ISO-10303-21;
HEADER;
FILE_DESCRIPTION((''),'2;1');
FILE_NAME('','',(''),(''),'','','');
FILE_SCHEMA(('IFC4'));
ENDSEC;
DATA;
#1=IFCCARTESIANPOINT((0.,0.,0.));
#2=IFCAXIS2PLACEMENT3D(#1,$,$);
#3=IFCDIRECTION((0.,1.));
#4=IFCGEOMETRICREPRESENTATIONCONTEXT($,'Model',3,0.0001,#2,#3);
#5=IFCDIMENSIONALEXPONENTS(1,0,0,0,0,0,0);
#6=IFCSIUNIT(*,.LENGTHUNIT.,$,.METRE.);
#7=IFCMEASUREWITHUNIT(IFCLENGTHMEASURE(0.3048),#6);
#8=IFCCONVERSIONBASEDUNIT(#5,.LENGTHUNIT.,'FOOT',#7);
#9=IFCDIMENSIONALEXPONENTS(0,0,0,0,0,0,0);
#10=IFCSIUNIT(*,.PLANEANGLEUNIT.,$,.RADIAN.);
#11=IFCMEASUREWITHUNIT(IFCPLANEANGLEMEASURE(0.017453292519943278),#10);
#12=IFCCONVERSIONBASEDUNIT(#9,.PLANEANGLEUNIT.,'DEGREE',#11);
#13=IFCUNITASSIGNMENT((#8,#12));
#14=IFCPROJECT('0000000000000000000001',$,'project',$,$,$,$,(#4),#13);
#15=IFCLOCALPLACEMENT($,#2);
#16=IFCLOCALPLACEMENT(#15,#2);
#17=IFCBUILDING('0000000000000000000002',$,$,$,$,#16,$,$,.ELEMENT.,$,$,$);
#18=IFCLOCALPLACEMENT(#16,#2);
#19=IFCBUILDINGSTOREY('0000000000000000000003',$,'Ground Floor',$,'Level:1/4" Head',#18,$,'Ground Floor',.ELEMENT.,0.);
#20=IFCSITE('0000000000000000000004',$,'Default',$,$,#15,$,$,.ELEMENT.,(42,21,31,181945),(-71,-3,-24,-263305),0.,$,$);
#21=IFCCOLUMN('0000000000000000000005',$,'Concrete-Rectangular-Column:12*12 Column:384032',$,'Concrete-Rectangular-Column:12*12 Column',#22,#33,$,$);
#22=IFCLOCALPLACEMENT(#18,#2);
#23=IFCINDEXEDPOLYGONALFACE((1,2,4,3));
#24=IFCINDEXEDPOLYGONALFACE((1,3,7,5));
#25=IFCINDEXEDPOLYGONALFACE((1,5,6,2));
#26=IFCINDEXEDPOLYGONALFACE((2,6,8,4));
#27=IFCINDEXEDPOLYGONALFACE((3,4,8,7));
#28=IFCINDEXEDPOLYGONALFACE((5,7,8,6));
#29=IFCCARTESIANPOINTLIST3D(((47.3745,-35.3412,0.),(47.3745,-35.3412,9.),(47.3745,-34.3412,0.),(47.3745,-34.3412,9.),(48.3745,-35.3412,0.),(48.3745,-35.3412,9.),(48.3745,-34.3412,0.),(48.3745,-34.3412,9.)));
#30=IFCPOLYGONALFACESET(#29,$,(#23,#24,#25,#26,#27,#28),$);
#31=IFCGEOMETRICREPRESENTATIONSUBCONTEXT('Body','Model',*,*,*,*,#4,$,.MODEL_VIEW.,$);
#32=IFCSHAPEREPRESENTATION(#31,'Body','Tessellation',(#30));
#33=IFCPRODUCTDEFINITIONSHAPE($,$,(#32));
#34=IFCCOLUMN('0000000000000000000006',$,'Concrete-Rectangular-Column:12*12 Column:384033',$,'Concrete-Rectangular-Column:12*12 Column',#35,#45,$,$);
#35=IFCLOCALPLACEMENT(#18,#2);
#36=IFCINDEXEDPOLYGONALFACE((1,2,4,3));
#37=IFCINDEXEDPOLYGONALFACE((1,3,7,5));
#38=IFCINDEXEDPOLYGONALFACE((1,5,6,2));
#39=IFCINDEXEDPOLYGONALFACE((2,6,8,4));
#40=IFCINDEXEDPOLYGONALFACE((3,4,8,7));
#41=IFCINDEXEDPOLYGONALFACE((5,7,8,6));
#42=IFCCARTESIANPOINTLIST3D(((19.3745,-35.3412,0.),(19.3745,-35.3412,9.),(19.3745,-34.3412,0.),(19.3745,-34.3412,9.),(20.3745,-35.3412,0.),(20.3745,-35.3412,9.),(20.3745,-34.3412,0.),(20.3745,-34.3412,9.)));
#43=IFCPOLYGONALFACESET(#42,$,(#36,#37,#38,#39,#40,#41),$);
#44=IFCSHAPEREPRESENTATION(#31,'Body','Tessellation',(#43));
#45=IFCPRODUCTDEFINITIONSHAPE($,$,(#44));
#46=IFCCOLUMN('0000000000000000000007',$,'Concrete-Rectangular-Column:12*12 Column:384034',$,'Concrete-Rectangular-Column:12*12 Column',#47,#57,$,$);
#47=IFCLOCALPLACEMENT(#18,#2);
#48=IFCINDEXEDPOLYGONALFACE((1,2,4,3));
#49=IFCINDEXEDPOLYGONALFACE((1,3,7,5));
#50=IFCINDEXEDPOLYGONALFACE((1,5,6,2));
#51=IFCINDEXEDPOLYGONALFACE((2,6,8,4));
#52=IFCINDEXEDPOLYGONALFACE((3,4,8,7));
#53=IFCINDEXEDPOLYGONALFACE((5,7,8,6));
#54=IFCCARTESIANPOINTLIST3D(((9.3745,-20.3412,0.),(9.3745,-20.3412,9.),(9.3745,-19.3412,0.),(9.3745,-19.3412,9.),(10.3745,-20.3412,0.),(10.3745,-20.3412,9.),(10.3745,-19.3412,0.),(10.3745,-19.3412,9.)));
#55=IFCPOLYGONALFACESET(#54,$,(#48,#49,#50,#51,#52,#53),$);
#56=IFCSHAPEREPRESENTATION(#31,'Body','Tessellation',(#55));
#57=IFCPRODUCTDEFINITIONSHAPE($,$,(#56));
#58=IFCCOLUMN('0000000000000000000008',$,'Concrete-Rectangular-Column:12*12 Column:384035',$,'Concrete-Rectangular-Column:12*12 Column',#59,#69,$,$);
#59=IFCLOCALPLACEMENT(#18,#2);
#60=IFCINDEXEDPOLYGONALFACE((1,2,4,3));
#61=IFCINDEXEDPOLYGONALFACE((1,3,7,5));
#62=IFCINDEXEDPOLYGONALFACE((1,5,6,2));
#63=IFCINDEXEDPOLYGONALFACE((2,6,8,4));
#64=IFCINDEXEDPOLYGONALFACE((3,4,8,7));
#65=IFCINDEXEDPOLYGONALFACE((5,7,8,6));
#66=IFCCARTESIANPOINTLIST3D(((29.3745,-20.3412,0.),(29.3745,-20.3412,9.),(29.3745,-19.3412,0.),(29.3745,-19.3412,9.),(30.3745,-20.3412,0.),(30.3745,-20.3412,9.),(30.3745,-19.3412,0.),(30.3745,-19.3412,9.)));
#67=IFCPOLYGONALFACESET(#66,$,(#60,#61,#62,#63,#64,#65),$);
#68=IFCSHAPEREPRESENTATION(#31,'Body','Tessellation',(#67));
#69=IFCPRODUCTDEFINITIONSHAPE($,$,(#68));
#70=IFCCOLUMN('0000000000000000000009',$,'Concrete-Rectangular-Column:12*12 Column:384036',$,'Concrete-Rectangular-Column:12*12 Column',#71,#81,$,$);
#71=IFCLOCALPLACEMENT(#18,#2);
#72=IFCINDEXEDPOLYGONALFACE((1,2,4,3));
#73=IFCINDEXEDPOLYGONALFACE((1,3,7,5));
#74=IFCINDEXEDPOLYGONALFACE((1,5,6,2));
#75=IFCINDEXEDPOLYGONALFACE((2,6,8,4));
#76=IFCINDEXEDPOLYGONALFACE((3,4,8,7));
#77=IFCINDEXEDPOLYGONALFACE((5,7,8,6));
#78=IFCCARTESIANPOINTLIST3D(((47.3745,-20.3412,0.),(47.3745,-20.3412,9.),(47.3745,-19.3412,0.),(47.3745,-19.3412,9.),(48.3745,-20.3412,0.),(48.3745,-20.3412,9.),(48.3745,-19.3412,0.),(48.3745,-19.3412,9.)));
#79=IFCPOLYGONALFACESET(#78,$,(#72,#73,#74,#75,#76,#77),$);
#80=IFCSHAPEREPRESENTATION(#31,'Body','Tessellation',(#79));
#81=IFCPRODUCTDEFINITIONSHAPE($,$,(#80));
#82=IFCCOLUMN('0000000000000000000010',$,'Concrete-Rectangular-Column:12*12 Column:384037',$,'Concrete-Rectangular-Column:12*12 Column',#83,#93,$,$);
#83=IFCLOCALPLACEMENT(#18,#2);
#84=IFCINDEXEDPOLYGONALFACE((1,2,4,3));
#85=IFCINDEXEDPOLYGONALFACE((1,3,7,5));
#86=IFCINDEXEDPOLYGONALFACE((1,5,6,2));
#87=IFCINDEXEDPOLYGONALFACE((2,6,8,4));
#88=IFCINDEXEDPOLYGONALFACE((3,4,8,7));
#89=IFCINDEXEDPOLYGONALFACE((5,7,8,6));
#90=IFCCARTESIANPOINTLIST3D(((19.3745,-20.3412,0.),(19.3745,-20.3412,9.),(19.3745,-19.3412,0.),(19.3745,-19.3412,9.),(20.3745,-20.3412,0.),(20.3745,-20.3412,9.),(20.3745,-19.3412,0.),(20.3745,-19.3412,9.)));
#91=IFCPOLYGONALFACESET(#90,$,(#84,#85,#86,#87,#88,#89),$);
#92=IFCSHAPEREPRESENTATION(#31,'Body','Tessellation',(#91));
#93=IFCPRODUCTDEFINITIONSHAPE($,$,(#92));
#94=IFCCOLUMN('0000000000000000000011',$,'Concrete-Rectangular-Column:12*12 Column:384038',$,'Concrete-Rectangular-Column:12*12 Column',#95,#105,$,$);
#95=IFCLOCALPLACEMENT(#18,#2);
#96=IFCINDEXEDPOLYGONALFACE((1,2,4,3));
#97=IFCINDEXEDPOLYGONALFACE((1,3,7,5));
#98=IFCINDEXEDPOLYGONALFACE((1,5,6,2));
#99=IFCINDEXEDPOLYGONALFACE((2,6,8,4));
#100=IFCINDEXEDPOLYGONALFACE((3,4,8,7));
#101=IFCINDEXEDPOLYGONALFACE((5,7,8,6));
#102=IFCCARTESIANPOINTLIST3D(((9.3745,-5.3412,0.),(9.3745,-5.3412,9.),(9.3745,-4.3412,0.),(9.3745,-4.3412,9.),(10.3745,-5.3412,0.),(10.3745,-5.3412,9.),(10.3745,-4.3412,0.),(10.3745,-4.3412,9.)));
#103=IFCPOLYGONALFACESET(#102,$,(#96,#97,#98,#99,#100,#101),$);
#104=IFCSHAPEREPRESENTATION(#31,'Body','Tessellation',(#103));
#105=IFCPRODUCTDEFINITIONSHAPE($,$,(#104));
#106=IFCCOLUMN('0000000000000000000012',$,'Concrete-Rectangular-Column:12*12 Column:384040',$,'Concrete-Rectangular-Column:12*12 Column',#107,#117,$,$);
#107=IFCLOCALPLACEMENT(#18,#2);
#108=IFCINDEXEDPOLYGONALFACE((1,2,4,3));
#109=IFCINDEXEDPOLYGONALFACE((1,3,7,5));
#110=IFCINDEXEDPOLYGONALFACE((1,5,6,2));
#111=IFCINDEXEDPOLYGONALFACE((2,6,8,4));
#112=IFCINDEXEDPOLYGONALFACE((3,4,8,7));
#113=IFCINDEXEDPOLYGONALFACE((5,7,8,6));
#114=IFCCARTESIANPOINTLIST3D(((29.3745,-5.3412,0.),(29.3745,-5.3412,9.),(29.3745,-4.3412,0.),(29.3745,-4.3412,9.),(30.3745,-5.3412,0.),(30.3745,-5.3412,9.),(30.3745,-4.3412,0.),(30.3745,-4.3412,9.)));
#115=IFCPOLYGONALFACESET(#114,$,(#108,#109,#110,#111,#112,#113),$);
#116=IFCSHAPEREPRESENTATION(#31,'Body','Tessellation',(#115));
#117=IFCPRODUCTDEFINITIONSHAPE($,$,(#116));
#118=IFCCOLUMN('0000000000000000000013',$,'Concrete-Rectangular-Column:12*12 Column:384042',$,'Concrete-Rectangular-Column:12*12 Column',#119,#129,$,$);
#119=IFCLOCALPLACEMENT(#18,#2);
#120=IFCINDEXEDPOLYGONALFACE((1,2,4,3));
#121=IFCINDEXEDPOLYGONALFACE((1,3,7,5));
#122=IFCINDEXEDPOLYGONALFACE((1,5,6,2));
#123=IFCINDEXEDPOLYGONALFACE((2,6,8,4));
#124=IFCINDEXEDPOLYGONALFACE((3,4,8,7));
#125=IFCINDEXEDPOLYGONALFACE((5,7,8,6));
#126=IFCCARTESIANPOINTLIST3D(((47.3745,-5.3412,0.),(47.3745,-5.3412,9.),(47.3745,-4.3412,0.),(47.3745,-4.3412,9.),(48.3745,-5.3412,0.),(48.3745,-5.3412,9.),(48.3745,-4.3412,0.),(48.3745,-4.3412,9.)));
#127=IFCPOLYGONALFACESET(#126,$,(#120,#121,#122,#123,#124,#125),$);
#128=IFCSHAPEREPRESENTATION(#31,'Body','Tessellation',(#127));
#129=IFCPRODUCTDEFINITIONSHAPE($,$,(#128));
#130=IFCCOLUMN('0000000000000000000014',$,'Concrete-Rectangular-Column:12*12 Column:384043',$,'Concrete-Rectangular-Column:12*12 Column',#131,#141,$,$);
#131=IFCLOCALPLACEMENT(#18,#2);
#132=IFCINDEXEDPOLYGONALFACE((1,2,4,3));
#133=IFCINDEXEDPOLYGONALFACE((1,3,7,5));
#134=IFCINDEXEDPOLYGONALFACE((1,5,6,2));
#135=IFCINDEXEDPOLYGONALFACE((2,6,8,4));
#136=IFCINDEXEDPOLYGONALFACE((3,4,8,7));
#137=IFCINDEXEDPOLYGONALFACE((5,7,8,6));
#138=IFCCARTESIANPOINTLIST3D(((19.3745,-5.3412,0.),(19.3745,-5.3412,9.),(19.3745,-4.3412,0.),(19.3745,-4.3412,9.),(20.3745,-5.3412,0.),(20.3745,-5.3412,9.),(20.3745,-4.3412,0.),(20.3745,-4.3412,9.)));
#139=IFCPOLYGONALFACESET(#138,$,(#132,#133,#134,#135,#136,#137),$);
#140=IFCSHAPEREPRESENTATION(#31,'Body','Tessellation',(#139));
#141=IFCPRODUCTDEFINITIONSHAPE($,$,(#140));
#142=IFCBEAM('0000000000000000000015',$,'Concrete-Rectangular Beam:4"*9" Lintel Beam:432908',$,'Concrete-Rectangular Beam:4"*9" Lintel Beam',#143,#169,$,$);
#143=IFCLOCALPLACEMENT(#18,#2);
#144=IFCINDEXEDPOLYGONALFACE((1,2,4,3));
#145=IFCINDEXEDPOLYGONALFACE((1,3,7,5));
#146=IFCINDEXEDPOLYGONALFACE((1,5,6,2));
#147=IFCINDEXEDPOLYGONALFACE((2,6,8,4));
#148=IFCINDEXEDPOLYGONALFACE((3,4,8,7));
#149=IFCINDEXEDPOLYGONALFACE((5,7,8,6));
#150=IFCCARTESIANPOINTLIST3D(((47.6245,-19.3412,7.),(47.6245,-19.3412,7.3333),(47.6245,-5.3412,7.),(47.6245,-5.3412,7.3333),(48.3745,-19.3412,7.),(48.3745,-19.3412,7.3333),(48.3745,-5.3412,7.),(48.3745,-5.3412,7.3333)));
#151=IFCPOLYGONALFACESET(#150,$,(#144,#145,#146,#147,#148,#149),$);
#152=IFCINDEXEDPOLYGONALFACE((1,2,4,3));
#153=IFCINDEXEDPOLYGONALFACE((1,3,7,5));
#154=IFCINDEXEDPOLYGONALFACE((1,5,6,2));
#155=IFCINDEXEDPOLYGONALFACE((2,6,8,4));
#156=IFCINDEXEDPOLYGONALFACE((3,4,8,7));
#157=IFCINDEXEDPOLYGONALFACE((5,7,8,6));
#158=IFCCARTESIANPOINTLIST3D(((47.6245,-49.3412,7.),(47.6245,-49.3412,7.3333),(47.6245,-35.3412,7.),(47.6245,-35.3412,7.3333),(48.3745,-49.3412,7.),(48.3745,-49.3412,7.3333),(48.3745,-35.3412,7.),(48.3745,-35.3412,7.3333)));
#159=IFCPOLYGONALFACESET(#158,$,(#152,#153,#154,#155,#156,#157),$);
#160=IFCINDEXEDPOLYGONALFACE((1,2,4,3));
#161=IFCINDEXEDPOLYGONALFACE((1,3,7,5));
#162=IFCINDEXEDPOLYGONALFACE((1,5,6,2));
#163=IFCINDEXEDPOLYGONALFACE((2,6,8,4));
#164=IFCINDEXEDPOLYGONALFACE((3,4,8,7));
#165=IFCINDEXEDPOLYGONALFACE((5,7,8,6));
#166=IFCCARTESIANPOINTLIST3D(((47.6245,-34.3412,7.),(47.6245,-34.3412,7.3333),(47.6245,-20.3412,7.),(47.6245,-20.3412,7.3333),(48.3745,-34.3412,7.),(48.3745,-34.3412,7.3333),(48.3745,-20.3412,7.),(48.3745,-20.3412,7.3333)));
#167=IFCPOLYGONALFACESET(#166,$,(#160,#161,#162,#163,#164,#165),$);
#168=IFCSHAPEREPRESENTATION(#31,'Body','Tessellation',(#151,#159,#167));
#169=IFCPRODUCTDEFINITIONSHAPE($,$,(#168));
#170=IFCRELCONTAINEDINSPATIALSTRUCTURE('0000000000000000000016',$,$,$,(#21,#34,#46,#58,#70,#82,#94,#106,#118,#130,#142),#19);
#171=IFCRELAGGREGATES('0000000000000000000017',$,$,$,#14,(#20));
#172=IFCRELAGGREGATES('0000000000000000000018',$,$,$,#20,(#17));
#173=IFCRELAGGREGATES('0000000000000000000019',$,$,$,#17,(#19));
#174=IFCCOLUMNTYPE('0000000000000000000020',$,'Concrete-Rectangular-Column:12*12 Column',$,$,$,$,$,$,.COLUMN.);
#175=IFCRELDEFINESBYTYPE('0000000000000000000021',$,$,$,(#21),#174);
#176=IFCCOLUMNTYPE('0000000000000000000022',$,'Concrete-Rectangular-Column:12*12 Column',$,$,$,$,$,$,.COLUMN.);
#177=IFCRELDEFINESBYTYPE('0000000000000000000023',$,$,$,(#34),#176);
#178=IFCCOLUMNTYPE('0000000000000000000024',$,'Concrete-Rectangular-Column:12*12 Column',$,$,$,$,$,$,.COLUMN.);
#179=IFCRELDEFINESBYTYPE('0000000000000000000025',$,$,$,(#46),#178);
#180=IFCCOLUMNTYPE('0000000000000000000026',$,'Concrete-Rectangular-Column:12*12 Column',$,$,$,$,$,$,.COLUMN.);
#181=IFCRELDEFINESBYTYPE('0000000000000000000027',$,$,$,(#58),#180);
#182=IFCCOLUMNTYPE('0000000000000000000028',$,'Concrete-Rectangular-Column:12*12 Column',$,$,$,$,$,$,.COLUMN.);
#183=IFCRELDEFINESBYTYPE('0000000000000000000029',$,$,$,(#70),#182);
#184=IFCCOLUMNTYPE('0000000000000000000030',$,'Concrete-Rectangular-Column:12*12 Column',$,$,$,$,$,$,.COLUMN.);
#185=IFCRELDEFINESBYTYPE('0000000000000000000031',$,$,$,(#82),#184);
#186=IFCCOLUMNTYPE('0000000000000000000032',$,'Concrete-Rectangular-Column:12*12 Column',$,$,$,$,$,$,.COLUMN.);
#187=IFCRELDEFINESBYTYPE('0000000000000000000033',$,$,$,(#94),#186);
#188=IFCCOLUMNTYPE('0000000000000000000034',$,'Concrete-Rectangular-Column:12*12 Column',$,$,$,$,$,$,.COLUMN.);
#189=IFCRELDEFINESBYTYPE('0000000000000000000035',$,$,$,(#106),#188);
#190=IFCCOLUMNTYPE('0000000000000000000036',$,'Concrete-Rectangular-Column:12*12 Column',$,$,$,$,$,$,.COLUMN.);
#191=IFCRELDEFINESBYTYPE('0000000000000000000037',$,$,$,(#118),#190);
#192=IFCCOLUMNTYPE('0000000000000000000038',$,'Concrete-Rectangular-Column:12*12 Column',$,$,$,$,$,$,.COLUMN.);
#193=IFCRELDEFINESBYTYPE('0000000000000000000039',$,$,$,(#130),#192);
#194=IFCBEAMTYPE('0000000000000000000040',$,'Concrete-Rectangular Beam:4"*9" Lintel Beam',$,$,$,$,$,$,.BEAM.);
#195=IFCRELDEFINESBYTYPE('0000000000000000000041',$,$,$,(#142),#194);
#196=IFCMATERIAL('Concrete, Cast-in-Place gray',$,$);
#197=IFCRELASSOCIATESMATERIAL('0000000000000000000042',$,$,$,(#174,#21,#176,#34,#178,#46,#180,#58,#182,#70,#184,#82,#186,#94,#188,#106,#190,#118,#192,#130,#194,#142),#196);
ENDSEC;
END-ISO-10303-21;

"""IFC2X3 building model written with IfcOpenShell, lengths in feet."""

from ifc_helpers import new_model, entity, si_unit, converted_unit, direction, frame, frame_2d, origin, origin_2d_with_axis, place, context, subcontext, project, spatial, rectangle, extrude, source, transform, mapped, material, type_object, type_shapes, element, save


model = new_model("IFC2X3")

# Units and contexts
model_context = context("Model", 3, precision=0.0001, world=origin(), true_north=direction((0.0, 1.0)))
body_context = subcontext(model_context, "Body", "Model", "MODEL_VIEW")
ifc_project = project(units=[converted_unit("LENGTHUNIT", "FOOT", entity("IfcLengthMeasure", 0.3048), si_unit("LENGTHUNIT", "METRE"), dimensions=[1, 0, 0, 0, 0, 0, 0]), converted_unit("PLANEANGLEUNIT", "DEGREE", entity("IfcPlaneAngleMeasure", 0.017453292519943278), si_unit("PLANEANGLEUNIT", "RADIAN"), dimensions=[0, 0, 0, 0, 0, 0, 0])], contexts=[model_context])

# Site, building, storey
site_placement = place(None, origin())
site = spatial("IfcSite", under=ifc_project, at=site_placement, Name="Default", CompositionType="ELEMENT", RefLatitude=(42, 21, 31, 181945), RefLongitude=(-71, -3, -24, -263305), RefElevation=0.0)
building_placement = place(site_placement, origin())
building = spatial("IfcBuilding", under=site, at=building_placement, CompositionType="ELEMENT")
storey_placement = place(building_placement, origin())
storey = spatial("IfcBuildingStorey", under=building, at=storey_placement, Name="Ground Floor", ObjectType="Level:1/4\" Head", LongName="Ground Floor", CompositionType="ELEMENT", Elevation=0.0)

# Columns
ifc_material_1 = material(Name="Concrete, Cast-in-Place gray")
column_type_1 = type_object("IfcColumnType", Name="Concrete-Rectangular-Column:12*12 Column", PredefinedType="COLUMN", material=ifc_material_1)
shared_shape_1 = source(origin(), body_context, "Body", "SweptSolid", [
    extrude(rectangle(XDim=1.0, YDim=1.0, at=origin_2d_with_axis()), frame((47.8745, -34.8412, 0.0), z_axis=(0.0, 0.0, 1.0), x_axis=(-1.0, 0.0, 0.0)), (0.0, 0.0, 1.0), 9.0),
])
type_shapes(column_type_1, [shared_shape_1])
column_1_placement = place(storey_placement, origin())
element("IfcColumn", 1, at=column_1_placement, inside=storey, type_object=column_type_1, material=ifc_material_1, Name="Concrete-Rectangular-Column:12*12 Column:384032", ObjectType="Concrete-Rectangular-Column:12*12 Column", context=body_context, shape_type="MappedRepresentation", body=[
    mapped(shared_shape_1, transform((0.0, 0.0, 0.0), scale=1.0)),
])
column_type_2 = type_object("IfcColumnType", Name="Concrete-Rectangular-Column:12*12 Column", PredefinedType="COLUMN", material=ifc_material_1)
shared_shape_2 = source(origin(), body_context, "Body", "SweptSolid", [
    extrude(rectangle(XDim=1.0, YDim=1.0, at=frame_2d((0.0, 0.0), x_axis=(1.0, 0.0))), frame((19.8745, -34.8412, 0.0), z_axis=(0.0, 0.0, 1.0), x_axis=(-1.0, 0.0, 0.0)), (0.0, 0.0, 1.0), 9.0),
])
type_shapes(column_type_2, [shared_shape_2])
column_2_placement = place(storey_placement, origin())
element("IfcColumn", 2, at=column_2_placement, inside=storey, type_object=column_type_2, material=ifc_material_1, Name="Concrete-Rectangular-Column:12*12 Column:384033", ObjectType="Concrete-Rectangular-Column:12*12 Column", context=body_context, shape_type="MappedRepresentation", body=[
    mapped(shared_shape_2, transform((0.0, 0.0, 0.0), scale=1.0)),
])
column_type_3 = type_object("IfcColumnType", Name="Concrete-Rectangular-Column:12*12 Column", PredefinedType="COLUMN", material=ifc_material_1)
shared_shape_3 = source(origin(), body_context, "Body", "SweptSolid", [
    extrude(rectangle(XDim=1.0, YDim=1.0, at=frame_2d((0.0, 0.0), x_axis=(1.0, 0.0))), frame((9.8745, -19.8412, 0.0), z_axis=(0.0, 0.0, 1.0), x_axis=(-1.0, 0.0, 0.0)), (0.0, 0.0, 1.0), 9.0),
])
type_shapes(column_type_3, [shared_shape_3])
column_3_placement = place(storey_placement, origin())
element("IfcColumn", 3, at=column_3_placement, inside=storey, type_object=column_type_3, material=ifc_material_1, Name="Concrete-Rectangular-Column:12*12 Column:384034", ObjectType="Concrete-Rectangular-Column:12*12 Column", context=body_context, shape_type="MappedRepresentation", body=[
    mapped(shared_shape_3, transform((0.0, 0.0, 0.0), scale=1.0)),
])
column_type_4 = type_object("IfcColumnType", Name="Concrete-Rectangular-Column:12*12 Column", PredefinedType="COLUMN", material=ifc_material_1)
shared_shape_4 = source(origin(), body_context, "Body", "SweptSolid", [
    extrude(rectangle(XDim=1.0, YDim=1.0, at=frame_2d((0.0, 0.0), x_axis=(1.0, 0.0))), frame((29.8745, -19.8412, 0.0), z_axis=(0.0, 0.0, 1.0), x_axis=(-1.0, 0.0, 0.0)), (0.0, 0.0, 1.0), 9.0),
])
type_shapes(column_type_4, [shared_shape_4])
column_4_placement = place(storey_placement, origin())
element("IfcColumn", 4, at=column_4_placement, inside=storey, type_object=column_type_4, material=ifc_material_1, Name="Concrete-Rectangular-Column:12*12 Column:384035", ObjectType="Concrete-Rectangular-Column:12*12 Column", context=body_context, shape_type="MappedRepresentation", body=[
    mapped(shared_shape_4, transform((0.0, 0.0, 0.0), scale=1.0)),
])
column_type_5 = type_object("IfcColumnType", Name="Concrete-Rectangular-Column:12*12 Column", PredefinedType="COLUMN", material=ifc_material_1)
shared_shape_5 = source(origin(), body_context, "Body", "SweptSolid", [
    extrude(rectangle(XDim=1.0, YDim=1.0, at=frame_2d((0.0, 0.0), x_axis=(1.0, 0.0))), frame((47.8745, -19.8412, 0.0), z_axis=(0.0, 0.0, 1.0), x_axis=(-1.0, 0.0, 0.0)), (0.0, 0.0, 1.0), 9.0),
])
type_shapes(column_type_5, [shared_shape_5])
column_5_placement = place(storey_placement, origin())
element("IfcColumn", 5, at=column_5_placement, inside=storey, type_object=column_type_5, material=ifc_material_1, Name="Concrete-Rectangular-Column:12*12 Column:384036", ObjectType="Concrete-Rectangular-Column:12*12 Column", context=body_context, shape_type="MappedRepresentation", body=[
    mapped(shared_shape_5, transform((0.0, 0.0, 0.0), scale=1.0)),
])
column_type_6 = type_object("IfcColumnType", Name="Concrete-Rectangular-Column:12*12 Column", PredefinedType="COLUMN", material=ifc_material_1)
shared_shape_6 = source(origin(), body_context, "Body", "SweptSolid", [
    extrude(rectangle(XDim=1.0, YDim=1.0, at=frame_2d((0.0, 0.0), x_axis=(1.0, 0.0))), frame((19.8745, -19.8412, 0.0), z_axis=(0.0, 0.0, 1.0), x_axis=(-1.0, 0.0, 0.0)), (0.0, 0.0, 1.0), 9.0),
])
type_shapes(column_type_6, [shared_shape_6])
column_6_placement = place(storey_placement, origin())
element("IfcColumn", 6, at=column_6_placement, inside=storey, type_object=column_type_6, material=ifc_material_1, Name="Concrete-Rectangular-Column:12*12 Column:384037", ObjectType="Concrete-Rectangular-Column:12*12 Column", context=body_context, shape_type="MappedRepresentation", body=[
    mapped(shared_shape_6, transform((0.0, 0.0, 0.0), scale=1.0)),
])
column_type_7 = type_object("IfcColumnType", Name="Concrete-Rectangular-Column:12*12 Column", PredefinedType="COLUMN", material=ifc_material_1)
shared_shape_7 = source(origin(), body_context, "Body", "SweptSolid", [
    extrude(rectangle(XDim=1.0, YDim=1.0, at=origin_2d_with_axis()), frame((9.8745, -4.8412, 0.0), z_axis=(0.0, 0.0, 1.0), x_axis=(-1.0, 0.0, 0.0)), (0.0, 0.0, 1.0), 9.0),
])
type_shapes(column_type_7, [shared_shape_7])
column_7_placement = place(storey_placement, origin())
element("IfcColumn", 7, at=column_7_placement, inside=storey, type_object=column_type_7, material=ifc_material_1, Name="Concrete-Rectangular-Column:12*12 Column:384038", ObjectType="Concrete-Rectangular-Column:12*12 Column", context=body_context, shape_type="MappedRepresentation", body=[
    mapped(shared_shape_7, transform((0.0, 0.0, 0.0), scale=1.0)),
])
column_type_8 = type_object("IfcColumnType", Name="Concrete-Rectangular-Column:12*12 Column", PredefinedType="COLUMN", material=ifc_material_1)
shared_shape_8 = source(origin(), body_context, "Body", "SweptSolid", [
    extrude(rectangle(XDim=1.0, YDim=1.0, at=frame_2d((0.0, 0.0), x_axis=(1.0, 0.0))), frame((29.8745, -4.8412, 0.0), z_axis=(0.0, 0.0, 1.0), x_axis=(-1.0, 0.0, 0.0)), (0.0, 0.0, 1.0), 9.0),
])
type_shapes(column_type_8, [shared_shape_8])
column_8_placement = place(storey_placement, origin())
element("IfcColumn", 8, at=column_8_placement, inside=storey, type_object=column_type_8, material=ifc_material_1, Name="Concrete-Rectangular-Column:12*12 Column:384040", ObjectType="Concrete-Rectangular-Column:12*12 Column", context=body_context, shape_type="MappedRepresentation", body=[
    mapped(shared_shape_8, transform((0.0, 0.0, 0.0), scale=1.0)),
])
column_type_9 = type_object("IfcColumnType", Name="Concrete-Rectangular-Column:12*12 Column", PredefinedType="COLUMN", material=ifc_material_1)
shared_shape_9 = source(origin(), body_context, "Body", "SweptSolid", [
    extrude(rectangle(XDim=1.0, YDim=1.0, at=frame_2d((0.0, 0.0), x_axis=(1.0, 0.0))), frame((47.8745, -4.8412, 0.0), z_axis=(0.0, 0.0, 1.0), x_axis=(-1.0, 0.0, 0.0)), (0.0, 0.0, 1.0), 9.0),
])
type_shapes(column_type_9, [shared_shape_9])
column_9_placement = place(storey_placement, origin())
element("IfcColumn", 9, at=column_9_placement, inside=storey, type_object=column_type_9, material=ifc_material_1, Name="Concrete-Rectangular-Column:12*12 Column:384042", ObjectType="Concrete-Rectangular-Column:12*12 Column", context=body_context, shape_type="MappedRepresentation", body=[
    mapped(shared_shape_9, transform((0.0, 0.0, 0.0), scale=1.0)),
])
column_type_10 = type_object("IfcColumnType", Name="Concrete-Rectangular-Column:12*12 Column", PredefinedType="COLUMN", material=ifc_material_1)
shared_shape_10 = source(origin(), body_context, "Body", "SweptSolid", [
    extrude(rectangle(XDim=1.0, YDim=1.0, at=frame_2d((0.0, 0.0), x_axis=(1.0, 0.0))), frame((19.8745, -4.8412, 0.0), z_axis=(0.0, 0.0, 1.0), x_axis=(-1.0, 0.0, 0.0)), (0.0, 0.0, 1.0), 9.0),
])
type_shapes(column_type_10, [shared_shape_10])
column_10_placement = place(storey_placement, origin())
element("IfcColumn", 10, at=column_10_placement, inside=storey, type_object=column_type_10, material=ifc_material_1, Name="Concrete-Rectangular-Column:12*12 Column:384043", ObjectType="Concrete-Rectangular-Column:12*12 Column", context=body_context, shape_type="MappedRepresentation", body=[
    mapped(shared_shape_10, transform((0.0, 0.0, 0.0), scale=1.0)),
])

# Beam
beam_type_1 = type_object("IfcBeamType", Name="Concrete-Rectangular Beam:4\"*9\" Lintel Beam", PredefinedType="BEAM", material=ifc_material_1)
shared_shape_11 = source(origin(), body_context, "Body", "SweptSolid", [
    extrude(rectangle(XDim=0.3333, YDim=0.75, at=frame_2d((0.0, 0.0), x_axis=(0.0, 1.0))), frame((47.9995, -19.3412, 7.1667), z_axis=(0.0, 1.0, 0.0), x_axis=(-1.0, 0.0, 0.0)), (0.0, 0.0, 1.0), 14.0),
    extrude(rectangle(XDim=0.3333, YDim=0.75, at=frame_2d((0.0, 0.0), x_axis=(0.0, 1.0))), frame((47.9995, -49.3412, 7.1667), z_axis=(0.0, 1.0, 0.0), x_axis=(-1.0, 0.0, 0.0)), (0.0, 0.0, 1.0), 14.0),
    extrude(rectangle(XDim=0.3333, YDim=0.75, at=frame_2d((0.0, 0.0), x_axis=(0.0, 1.0))), frame((47.9995, -34.3412, 7.1667), z_axis=(0.0, 1.0, 0.0), x_axis=(-1.0, 0.0, 0.0)), (0.0, 0.0, 1.0), 14.0),
])
type_shapes(beam_type_1, [shared_shape_11])
beam_1_placement = place(storey_placement, origin())
element("IfcBeam", 11, at=beam_1_placement, inside=storey, type_object=beam_type_1, material=ifc_material_1, Name="Concrete-Rectangular Beam:4\"*9\" Lintel Beam:432908", ObjectType="Concrete-Rectangular Beam:4\"*9\" Lintel Beam", context=body_context, shape_type="MappedRepresentation", body=[
    mapped(shared_shape_11, transform((0.0, 0.0, 0.0), scale=1.0)),
])

save(model, "model.ifc")
